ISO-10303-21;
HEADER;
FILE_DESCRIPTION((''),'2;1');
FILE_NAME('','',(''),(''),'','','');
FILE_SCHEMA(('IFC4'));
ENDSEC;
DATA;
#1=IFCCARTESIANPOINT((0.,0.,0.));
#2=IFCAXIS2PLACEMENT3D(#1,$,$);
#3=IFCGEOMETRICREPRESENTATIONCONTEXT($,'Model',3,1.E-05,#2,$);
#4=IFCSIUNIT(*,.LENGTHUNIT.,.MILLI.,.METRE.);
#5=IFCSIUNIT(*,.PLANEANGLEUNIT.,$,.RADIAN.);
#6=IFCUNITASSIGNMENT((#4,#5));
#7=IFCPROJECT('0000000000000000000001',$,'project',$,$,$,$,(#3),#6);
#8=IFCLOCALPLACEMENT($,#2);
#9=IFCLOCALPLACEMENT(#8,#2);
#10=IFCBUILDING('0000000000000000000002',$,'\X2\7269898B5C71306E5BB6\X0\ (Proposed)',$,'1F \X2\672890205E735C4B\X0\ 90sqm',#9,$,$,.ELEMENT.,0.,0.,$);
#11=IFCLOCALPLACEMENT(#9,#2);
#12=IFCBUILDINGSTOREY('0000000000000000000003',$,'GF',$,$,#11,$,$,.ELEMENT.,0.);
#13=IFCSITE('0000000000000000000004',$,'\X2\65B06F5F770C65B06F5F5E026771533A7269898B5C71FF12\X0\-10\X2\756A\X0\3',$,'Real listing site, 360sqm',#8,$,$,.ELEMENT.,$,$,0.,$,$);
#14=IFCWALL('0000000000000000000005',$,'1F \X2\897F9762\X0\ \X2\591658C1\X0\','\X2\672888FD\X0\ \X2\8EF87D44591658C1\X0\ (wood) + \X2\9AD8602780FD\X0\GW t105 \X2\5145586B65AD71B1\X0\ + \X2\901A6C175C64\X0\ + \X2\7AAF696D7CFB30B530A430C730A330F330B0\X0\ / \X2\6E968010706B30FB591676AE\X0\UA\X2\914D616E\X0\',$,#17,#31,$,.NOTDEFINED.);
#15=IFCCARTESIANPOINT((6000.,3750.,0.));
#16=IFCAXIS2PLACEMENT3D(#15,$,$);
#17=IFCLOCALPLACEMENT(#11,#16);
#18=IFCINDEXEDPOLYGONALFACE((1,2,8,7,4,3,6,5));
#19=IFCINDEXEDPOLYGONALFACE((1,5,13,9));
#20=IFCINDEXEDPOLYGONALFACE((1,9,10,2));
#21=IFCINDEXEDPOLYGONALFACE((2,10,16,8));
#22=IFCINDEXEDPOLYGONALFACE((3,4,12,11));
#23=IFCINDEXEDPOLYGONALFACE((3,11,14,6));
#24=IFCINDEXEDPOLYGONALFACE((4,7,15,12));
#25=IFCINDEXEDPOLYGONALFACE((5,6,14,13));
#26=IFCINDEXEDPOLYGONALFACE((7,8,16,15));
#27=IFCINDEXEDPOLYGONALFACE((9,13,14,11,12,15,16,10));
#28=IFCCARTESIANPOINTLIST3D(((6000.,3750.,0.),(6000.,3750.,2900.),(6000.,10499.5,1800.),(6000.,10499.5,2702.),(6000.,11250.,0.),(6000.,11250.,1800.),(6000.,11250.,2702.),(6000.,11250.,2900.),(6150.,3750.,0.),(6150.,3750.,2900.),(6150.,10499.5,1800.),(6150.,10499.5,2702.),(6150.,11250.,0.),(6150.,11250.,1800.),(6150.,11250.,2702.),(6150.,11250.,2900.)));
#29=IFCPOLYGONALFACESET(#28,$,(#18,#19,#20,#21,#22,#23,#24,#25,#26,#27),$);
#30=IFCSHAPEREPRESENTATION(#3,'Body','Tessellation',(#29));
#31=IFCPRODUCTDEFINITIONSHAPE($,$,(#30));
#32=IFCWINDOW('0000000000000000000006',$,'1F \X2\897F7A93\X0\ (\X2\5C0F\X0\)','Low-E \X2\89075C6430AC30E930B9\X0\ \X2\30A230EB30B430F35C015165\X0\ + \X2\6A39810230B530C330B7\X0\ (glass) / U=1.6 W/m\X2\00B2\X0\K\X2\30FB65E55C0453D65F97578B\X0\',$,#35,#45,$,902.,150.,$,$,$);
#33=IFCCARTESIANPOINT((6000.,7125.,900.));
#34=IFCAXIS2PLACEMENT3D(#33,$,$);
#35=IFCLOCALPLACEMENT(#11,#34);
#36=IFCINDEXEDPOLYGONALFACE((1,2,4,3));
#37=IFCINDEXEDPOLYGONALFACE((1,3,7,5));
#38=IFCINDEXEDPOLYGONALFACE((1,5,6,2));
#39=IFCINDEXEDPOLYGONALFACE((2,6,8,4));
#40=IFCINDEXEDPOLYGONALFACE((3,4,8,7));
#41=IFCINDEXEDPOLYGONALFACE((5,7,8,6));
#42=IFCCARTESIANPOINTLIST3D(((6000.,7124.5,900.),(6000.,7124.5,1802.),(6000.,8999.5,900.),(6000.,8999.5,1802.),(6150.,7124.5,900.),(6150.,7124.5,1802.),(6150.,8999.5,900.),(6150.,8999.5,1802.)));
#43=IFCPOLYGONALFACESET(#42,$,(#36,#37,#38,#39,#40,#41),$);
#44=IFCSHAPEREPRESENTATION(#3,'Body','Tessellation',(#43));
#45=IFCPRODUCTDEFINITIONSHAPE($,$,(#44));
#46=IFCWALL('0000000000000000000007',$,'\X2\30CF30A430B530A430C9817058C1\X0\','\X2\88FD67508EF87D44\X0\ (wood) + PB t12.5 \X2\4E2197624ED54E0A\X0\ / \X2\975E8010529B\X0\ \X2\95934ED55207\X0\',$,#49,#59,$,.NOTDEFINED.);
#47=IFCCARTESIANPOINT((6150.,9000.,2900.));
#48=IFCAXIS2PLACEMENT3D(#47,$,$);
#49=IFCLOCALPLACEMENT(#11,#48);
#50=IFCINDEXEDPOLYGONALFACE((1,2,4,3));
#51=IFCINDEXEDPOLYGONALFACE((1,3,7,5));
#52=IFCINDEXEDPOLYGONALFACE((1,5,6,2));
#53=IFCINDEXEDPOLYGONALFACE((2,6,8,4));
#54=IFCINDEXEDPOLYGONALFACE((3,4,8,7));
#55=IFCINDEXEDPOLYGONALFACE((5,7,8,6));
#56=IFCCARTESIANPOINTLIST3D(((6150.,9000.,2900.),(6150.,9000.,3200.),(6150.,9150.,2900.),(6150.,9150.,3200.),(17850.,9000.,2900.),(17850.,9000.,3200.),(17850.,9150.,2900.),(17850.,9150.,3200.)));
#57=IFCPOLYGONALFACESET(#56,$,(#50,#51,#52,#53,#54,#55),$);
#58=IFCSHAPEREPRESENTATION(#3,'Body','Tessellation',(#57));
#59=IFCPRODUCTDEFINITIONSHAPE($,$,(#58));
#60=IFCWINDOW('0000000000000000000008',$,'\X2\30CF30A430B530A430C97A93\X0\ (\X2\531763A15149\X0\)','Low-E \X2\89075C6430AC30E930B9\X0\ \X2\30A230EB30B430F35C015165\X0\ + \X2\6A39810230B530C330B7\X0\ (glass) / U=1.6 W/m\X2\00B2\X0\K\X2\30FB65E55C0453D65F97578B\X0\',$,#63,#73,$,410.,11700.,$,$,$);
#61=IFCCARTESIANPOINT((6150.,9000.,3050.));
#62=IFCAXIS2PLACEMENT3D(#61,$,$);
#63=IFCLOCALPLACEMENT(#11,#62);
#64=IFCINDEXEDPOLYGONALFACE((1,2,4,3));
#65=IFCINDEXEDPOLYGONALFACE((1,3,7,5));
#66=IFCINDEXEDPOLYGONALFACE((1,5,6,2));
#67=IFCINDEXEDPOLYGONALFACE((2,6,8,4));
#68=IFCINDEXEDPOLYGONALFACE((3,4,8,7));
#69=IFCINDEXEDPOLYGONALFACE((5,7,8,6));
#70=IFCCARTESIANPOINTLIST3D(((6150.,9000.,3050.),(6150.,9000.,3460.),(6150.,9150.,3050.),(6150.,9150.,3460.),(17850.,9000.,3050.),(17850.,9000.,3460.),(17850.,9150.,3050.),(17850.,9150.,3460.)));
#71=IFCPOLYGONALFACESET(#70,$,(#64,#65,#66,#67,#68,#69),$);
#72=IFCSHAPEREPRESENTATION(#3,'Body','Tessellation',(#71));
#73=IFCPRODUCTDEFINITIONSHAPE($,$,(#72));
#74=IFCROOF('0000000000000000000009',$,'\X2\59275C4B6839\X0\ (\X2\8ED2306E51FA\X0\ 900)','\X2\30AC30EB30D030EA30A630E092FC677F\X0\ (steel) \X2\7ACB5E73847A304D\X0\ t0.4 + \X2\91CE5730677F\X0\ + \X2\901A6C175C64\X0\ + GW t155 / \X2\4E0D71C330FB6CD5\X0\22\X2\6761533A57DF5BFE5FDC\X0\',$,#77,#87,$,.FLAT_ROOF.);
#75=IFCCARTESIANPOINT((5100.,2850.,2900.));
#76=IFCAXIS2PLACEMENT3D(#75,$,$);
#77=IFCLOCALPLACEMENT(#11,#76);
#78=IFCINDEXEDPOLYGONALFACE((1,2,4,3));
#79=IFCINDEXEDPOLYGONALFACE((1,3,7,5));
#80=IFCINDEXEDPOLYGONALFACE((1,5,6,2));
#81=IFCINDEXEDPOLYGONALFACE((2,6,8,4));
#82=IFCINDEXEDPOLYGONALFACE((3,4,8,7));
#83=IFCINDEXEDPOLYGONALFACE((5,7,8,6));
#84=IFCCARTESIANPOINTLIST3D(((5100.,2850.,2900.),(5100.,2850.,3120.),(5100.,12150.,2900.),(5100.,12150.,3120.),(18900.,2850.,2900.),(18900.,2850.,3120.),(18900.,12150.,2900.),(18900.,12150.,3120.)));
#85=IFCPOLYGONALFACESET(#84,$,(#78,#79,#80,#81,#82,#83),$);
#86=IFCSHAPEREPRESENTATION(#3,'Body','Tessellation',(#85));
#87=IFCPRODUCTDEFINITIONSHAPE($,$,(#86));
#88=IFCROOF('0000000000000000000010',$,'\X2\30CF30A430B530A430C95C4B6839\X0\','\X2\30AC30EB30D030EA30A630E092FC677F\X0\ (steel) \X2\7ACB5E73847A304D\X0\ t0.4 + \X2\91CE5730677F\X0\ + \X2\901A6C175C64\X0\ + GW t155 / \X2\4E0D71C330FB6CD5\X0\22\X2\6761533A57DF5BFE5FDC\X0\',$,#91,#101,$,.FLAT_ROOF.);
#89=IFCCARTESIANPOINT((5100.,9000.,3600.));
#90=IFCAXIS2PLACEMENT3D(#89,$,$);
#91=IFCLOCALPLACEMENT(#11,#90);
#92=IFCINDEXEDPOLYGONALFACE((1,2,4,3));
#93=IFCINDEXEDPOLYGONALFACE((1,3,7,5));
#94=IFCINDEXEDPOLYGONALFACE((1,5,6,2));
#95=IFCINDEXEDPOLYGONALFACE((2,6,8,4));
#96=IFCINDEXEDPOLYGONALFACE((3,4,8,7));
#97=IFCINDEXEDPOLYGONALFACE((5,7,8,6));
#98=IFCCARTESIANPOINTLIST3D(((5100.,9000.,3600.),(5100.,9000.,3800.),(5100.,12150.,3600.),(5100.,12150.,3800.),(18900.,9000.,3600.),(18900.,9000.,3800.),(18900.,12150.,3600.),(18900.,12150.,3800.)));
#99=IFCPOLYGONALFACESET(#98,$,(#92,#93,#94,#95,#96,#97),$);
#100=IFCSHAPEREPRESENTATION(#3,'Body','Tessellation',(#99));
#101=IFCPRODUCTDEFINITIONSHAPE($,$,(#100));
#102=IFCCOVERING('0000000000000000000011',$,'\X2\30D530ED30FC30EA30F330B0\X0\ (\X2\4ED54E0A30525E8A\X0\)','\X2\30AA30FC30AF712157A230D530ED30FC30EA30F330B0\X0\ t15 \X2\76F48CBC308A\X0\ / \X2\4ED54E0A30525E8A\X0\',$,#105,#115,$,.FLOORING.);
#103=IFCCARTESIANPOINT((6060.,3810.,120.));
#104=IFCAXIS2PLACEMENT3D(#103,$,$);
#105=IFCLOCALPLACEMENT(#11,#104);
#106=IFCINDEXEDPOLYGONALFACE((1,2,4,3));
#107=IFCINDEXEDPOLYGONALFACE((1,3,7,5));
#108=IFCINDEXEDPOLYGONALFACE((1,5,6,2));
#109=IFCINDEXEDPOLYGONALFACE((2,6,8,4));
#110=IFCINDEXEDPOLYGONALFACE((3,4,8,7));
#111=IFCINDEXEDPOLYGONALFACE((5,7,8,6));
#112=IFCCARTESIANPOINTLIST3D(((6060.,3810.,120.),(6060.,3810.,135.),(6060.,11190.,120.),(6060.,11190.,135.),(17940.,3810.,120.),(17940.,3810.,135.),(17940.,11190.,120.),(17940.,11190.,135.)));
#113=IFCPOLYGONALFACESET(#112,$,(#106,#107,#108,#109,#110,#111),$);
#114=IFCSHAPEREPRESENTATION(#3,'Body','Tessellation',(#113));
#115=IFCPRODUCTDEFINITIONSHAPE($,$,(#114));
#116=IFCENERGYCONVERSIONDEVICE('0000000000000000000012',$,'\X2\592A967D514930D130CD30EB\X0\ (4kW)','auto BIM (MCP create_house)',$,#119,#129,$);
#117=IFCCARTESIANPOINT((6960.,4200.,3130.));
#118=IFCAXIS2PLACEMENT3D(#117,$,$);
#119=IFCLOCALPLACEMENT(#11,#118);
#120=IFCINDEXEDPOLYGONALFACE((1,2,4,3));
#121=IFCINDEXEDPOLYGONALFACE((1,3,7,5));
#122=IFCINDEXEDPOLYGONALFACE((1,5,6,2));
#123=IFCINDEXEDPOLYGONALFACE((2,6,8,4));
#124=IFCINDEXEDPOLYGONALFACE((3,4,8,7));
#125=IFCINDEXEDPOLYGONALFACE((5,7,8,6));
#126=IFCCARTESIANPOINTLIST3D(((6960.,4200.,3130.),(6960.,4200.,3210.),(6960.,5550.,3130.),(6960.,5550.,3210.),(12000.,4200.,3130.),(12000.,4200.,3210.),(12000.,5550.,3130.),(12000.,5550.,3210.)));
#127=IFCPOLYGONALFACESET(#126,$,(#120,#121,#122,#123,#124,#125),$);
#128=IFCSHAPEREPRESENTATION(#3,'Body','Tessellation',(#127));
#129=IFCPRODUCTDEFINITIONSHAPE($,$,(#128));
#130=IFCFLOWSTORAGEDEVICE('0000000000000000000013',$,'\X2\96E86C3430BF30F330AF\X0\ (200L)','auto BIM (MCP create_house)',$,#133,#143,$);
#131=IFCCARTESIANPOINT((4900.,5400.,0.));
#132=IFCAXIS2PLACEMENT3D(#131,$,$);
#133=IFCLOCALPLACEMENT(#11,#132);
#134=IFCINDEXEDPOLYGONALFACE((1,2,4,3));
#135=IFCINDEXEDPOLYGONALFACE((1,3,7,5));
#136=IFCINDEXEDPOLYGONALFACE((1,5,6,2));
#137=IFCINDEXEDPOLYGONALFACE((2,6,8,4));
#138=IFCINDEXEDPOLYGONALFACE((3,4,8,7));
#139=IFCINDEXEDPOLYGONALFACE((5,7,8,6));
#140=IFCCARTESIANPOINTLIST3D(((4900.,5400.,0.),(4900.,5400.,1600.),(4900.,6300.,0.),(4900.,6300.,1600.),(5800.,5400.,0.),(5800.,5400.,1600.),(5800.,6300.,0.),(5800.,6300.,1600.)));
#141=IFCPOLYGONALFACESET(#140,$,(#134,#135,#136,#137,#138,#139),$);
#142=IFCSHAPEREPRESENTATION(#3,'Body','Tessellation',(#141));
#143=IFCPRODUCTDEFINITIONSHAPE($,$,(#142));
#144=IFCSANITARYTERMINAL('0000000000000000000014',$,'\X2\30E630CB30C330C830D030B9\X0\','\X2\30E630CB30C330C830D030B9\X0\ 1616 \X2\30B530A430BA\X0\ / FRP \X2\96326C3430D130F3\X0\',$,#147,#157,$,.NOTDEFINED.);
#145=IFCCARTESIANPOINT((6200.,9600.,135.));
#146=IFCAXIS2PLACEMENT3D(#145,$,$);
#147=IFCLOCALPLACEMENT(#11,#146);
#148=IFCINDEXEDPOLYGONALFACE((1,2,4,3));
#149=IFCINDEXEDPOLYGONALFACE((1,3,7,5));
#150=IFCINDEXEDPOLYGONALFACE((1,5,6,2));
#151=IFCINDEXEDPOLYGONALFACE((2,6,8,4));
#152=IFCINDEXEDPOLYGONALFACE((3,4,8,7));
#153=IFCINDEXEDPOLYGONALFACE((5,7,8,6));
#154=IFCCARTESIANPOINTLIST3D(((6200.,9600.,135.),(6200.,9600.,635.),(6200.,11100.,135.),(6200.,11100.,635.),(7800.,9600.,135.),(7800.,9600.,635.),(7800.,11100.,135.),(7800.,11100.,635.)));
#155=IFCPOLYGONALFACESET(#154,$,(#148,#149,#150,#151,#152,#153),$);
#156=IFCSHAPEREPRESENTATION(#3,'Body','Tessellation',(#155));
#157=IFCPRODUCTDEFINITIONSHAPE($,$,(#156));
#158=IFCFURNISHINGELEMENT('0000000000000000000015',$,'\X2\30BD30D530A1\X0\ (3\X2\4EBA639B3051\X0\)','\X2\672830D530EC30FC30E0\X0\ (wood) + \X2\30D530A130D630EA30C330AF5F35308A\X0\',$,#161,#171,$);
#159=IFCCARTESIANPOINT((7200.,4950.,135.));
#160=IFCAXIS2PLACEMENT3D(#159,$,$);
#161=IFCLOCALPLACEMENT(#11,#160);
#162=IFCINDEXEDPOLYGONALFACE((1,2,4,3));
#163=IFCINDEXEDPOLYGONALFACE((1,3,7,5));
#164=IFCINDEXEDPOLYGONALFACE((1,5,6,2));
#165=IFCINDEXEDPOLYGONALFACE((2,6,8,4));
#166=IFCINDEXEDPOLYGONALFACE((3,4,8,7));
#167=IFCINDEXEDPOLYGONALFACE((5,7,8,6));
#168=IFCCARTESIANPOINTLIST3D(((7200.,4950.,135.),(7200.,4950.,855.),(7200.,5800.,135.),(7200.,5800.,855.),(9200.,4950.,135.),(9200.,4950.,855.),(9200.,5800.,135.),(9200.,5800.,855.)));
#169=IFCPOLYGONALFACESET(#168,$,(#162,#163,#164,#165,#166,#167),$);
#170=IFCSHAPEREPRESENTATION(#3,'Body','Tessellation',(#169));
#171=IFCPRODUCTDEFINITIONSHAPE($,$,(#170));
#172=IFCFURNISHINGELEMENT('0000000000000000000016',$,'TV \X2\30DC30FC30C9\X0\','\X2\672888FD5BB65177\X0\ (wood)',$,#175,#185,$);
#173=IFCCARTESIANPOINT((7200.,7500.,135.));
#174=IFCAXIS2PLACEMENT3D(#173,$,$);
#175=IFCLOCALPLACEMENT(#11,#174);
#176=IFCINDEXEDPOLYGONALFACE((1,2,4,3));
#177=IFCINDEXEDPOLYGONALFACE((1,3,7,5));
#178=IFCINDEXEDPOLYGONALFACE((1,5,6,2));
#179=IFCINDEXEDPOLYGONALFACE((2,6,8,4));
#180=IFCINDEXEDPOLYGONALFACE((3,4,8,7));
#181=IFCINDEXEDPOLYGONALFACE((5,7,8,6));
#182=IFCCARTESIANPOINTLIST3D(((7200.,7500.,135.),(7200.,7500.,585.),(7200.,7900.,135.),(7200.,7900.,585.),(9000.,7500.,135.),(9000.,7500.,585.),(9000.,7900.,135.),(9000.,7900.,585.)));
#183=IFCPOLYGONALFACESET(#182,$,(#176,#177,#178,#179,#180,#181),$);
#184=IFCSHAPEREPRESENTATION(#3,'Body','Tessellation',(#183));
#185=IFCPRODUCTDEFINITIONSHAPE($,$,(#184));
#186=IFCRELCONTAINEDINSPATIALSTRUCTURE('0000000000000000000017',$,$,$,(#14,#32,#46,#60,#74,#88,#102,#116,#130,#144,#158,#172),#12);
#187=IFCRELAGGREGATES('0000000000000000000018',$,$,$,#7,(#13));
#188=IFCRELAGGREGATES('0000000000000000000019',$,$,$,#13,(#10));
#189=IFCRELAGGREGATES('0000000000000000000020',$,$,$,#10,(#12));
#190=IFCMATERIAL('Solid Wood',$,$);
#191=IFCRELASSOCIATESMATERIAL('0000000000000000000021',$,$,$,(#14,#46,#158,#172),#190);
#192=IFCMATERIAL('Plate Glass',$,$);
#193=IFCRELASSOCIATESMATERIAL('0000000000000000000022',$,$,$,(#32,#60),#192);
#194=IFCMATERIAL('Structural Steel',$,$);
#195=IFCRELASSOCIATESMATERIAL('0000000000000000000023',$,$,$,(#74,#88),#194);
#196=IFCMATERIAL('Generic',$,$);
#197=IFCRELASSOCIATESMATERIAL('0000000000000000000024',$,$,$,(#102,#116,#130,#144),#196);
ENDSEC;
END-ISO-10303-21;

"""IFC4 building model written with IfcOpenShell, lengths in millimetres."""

from ifc_helpers import new_model, si_unit, frame, frame_2d, origin, place, context, project, spatial, rectangle, extrude, material, element, fill, save


model = new_model("IFC4")

# Units and contexts
model_context = context("Model", 3, precision=1e-05, world=origin())
ifc_project = project(units=[si_unit("LENGTHUNIT", "METRE", prefix="MILLI"), si_unit("PLANEANGLEUNIT", "RADIAN")], contexts=[model_context])

# Site, building, storey
site_placement = place(None, origin())
site = spatial("IfcSite", under=ifc_project, at=site_placement, Name="新潟県新潟市東区物見山２-10番3", ObjectType="Real listing site, 360sqm", CompositionType="ELEMENT", RefElevation=0.0)
building_placement = place(site_placement, origin())
building = spatial("IfcBuilding", under=site, at=building_placement, Name="物見山の家 (Proposed)", ObjectType="1F 木造平屋 90sqm", CompositionType="ELEMENT", ElevationOfRefHeight=0.0, ElevationOfTerrain=0.0)
storey_placement = place(building_placement, origin())
storey = spatial("IfcBuildingStorey", under=building, at=storey_placement, Name="GF", CompositionType="ELEMENT", Elevation=0.0)

# Shared definitions
ifc_material_1 = material(Name="Solid Wood")

# Shared definitions
ifc_material_2 = material(Name="Plate Glass")

# Wall, opening, window
wall_1_placement = place(storey_placement, frame((6000.0, 3750.0, 0.0)))
wall_1 = element("IfcWall", 1, at=wall_1_placement, inside=storey, material=ifc_material_1, Name="1F 西面 外壁", Description="木製 軸組外壁 (wood) + 高性能GW t105 充填断熱 + 通気層 + 窯業系サイディング / 準耐火・外皮UA配慮", PredefinedType="NOTDEFINED", context=model_context, shape_type="SweptSolid", body=[
    extrude(rectangle(XDim=150.0, YDim=7500.0, at=frame_2d((75.0, 3750.0))), frame((6000.0, 3750.0, 0.0)), (0.0, 0.0, 1.0), 2900.0),
])
opening_1_placement = place(storey_placement, frame((6000.0, 7125.0, 900.0)))
opening_1 = element("IfcOpeningElement", 2, at=opening_1_placement, cuts=wall_1, PredefinedType="NOTDEFINED", context=model_context, shape_type="SweptSolid", body=[
    extrude(rectangle(XDim=150.0, YDim=1875.0, at=frame_2d((75.0, 937.0))), frame((6000.0, 7125.0, 900.0)), (0.0, 0.0, 1.0), 902.0),
])
window_1_placement = place(storey_placement, frame((6000.0, 7125.0, 900.0)))
window_1 = element("IfcWindow", 3, at=window_1_placement, inside=storey, material=ifc_material_2, Name="1F 西窓 (小)", Description="Low-E 複層ガラス アルゴン封入 + 樹脂サッシ (glass) / U=1.6 W/m²K・日射取得型", OverallHeight=902.0, OverallWidth=150.0, context=model_context, shape_type="SweptSolid", body=[
    extrude(rectangle(XDim=150.0, YDim=1875.0, at=frame_2d((75.0, 937.0))), frame((6000.0, 7125.0, 900.0)), (0.0, 0.0, 1.0), 902.0),
])
fill(opening_1, window_1)

# Wall, opening, window
wall_2_placement = place(storey_placement, frame((6150.0, 9000.0, 2900.0)))
wall_2 = element("IfcWall", 4, at=wall_2_placement, inside=storey, material=ifc_material_1, Name="ハイサイド腰壁", Description="製材軸組 (wood) + PB t12.5 両面仕上 / 非耐力 間仕切", PredefinedType="NOTDEFINED", context=model_context, shape_type="SweptSolid", body=[
    extrude(rectangle(XDim=11700.0, YDim=150.0, at=frame_2d((5850.0, 75.0))), frame((6150.0, 9000.0, 2900.0)), (0.0, 0.0, 1.0), 700.0),
])
opening_2_placement = place(storey_placement, frame((6150.0, 9000.0, 3050.0)))
opening_2 = element("IfcOpeningElement", 5, at=opening_2_placement, cuts=wall_2, PredefinedType="NOTDEFINED", context=model_context, shape_type="SweptSolid", body=[
    extrude(rectangle(XDim=11700.0, YDim=150.0, at=frame_2d((5850.0, 75.0))), frame((6150.0, 9000.0, 3050.0)), (0.0, 0.0, 1.0), 410.0),
])
window_2_placement = place(storey_placement, frame((6150.0, 9000.0, 3050.0)))
window_2 = element("IfcWindow", 6, at=window_2_placement, inside=storey, material=ifc_material_2, Name="ハイサイド窓 (北採光)", Description="Low-E 複層ガラス アルゴン封入 + 樹脂サッシ (glass) / U=1.6 W/m²K・日射取得型", OverallHeight=410.0, OverallWidth=11700.0, context=model_context, shape_type="SweptSolid", body=[
    extrude(rectangle(XDim=11700.0, YDim=150.0, at=frame_2d((5850.0, 75.0))), frame((6150.0, 9000.0, 3050.0)), (0.0, 0.0, 1.0), 410.0),
])
fill(opening_2, window_2)

# Roofs
ifc_material_3 = material(Name="Structural Steel")
roof_1_placement = place(storey_placement, frame((5100.0, 2850.0, 2900.0)))
element("IfcRoof", 7, at=roof_1_placement, inside=storey, material=ifc_material_3, Name="大屋根 (軒の出 900)", Description="ガルバリウム鋼板 (steel) 立平葺き t0.4 + 野地板 + 通気層 + GW t155 / 不燃・法22条区域対応", PredefinedType="FLAT_ROOF", context=model_context, shape_type="SweptSolid", body=[
    extrude(rectangle(XDim=13800.0, YDim=9300.0, at=frame_2d((6900.0, 4650.0))), frame((5100.0, 2850.0, 2900.0)), (0.0, 0.0, 1.0), 220.0),
])
roof_2_placement = place(storey_placement, frame((5100.0, 9000.0, 3600.0)))
element("IfcRoof", 8, at=roof_2_placement, inside=storey, material=ifc_material_3, Name="ハイサイド屋根", Description="ガルバリウム鋼板 (steel) 立平葺き t0.4 + 野地板 + 通気層 + GW t155 / 不燃・法22条区域対応", PredefinedType="FLAT_ROOF", context=model_context, shape_type="SweptSolid", body=[
    extrude(rectangle(XDim=13800.0, YDim=3150.0, at=frame_2d((6900.0, 1575.0))), frame((5100.0, 9000.0, 3600.0)), (0.0, 0.0, 1.0), 200.0),
])

# Covering
ifc_material_4 = material(Name="Generic")
covering_placement = place(storey_placement, frame((6060.0, 3810.0, 120.0)))
element("IfcCovering", 9, at=covering_placement, inside=storey, material=ifc_material_4, Name="フローリング (仕上げ床)", Description="オーク無垢フローリング t15 直貼り / 仕上げ床", PredefinedType="FLOORING", context=model_context, shape_type="SweptSolid", body=[
    extrude(rectangle(XDim=11880.0, YDim=7380.0, at=frame_2d((5940.0, 3690.0))), frame((6060.0, 3810.0, 120.0)), (0.0, 0.0, 1.0), 15.0),
])

# Energy conversion device
energy_conversion_device_placement = place(storey_placement, frame((6960.0, 4200.0, 3130.0)))
element("IfcEnergyConversionDevice", 10, at=energy_conversion_device_placement, inside=storey, material=ifc_material_4, Name="太陽光パネル (4kW)", Description="auto BIM (MCP create_house)", context=model_context, shape_type="SweptSolid", body=[
    extrude(rectangle(XDim=5040.0, YDim=1350.0, at=frame_2d((2520.0, 675.0))), frame((6960.0, 4200.0, 3130.0)), (0.0, 0.0, 1.0), 80.0),
])

# Flow storage device
flow_storage_device_placement = place(storey_placement, frame((4900.0, 5400.0, 0.0)))
element("IfcFlowStorageDevice", 11, at=flow_storage_device_placement, inside=storey, material=ifc_material_4, Name="雨水タンク (200L)", Description="auto BIM (MCP create_house)", context=model_context, shape_type="SweptSolid", body=[
    extrude(rectangle(XDim=900.0, YDim=900.0, at=frame_2d((450.0, 450.0))), frame((4900.0, 5400.0, 0.0)), (0.0, 0.0, 1.0), 1600.0),
])

# Sanitary terminal
sanitary_terminal_placement = place(storey_placement, frame((6200.0, 9600.0, 135.0)))
element("IfcSanitaryTerminal", 12, at=sanitary_terminal_placement, inside=storey, material=ifc_material_4, Name="ユニットバス", Description="ユニットバス 1616 サイズ / FRP 防水パン", PredefinedType="NOTDEFINED", context=model_context, shape_type="SweptSolid", body=[
    extrude(rectangle(XDim=1600.0, YDim=1500.0, at=frame_2d((800.0, 750.0))), frame((6200.0, 9600.0, 135.0)), (0.0, 0.0, 1.0), 500.0),
])

# Furnishing elements
furnishing_1_placement = place(storey_placement, frame((7200.0, 4950.0, 135.0)))
element("IfcFurnishingElement", 13, at=furnishing_1_placement, inside=storey, material=ifc_material_1, Name="ソファ (3人掛け)", Description="木フレーム (wood) + ファブリック張り", context=model_context, shape_type="SweptSolid", body=[
    extrude(rectangle(XDim=2000.0, YDim=850.0, at=frame_2d((1000.0, 425.0))), frame((7200.0, 4950.0, 135.0)), (0.0, 0.0, 1.0), 720.0),
])
furnishing_2_placement = place(storey_placement, frame((7200.0, 7500.0, 135.0)))
element("IfcFurnishingElement", 14, at=furnishing_2_placement, inside=storey, material=ifc_material_1, Name="TV ボード", Description="木製家具 (wood)", context=model_context, shape_type="SweptSolid", body=[
    extrude(rectangle(XDim=1800.0, YDim=400.0, at=frame_2d((900.0, 200.0))), frame((7200.0, 7500.0, 135.0)), (0.0, 0.0, 1.0), 450.0),
])

save(model, "model.ifc")
